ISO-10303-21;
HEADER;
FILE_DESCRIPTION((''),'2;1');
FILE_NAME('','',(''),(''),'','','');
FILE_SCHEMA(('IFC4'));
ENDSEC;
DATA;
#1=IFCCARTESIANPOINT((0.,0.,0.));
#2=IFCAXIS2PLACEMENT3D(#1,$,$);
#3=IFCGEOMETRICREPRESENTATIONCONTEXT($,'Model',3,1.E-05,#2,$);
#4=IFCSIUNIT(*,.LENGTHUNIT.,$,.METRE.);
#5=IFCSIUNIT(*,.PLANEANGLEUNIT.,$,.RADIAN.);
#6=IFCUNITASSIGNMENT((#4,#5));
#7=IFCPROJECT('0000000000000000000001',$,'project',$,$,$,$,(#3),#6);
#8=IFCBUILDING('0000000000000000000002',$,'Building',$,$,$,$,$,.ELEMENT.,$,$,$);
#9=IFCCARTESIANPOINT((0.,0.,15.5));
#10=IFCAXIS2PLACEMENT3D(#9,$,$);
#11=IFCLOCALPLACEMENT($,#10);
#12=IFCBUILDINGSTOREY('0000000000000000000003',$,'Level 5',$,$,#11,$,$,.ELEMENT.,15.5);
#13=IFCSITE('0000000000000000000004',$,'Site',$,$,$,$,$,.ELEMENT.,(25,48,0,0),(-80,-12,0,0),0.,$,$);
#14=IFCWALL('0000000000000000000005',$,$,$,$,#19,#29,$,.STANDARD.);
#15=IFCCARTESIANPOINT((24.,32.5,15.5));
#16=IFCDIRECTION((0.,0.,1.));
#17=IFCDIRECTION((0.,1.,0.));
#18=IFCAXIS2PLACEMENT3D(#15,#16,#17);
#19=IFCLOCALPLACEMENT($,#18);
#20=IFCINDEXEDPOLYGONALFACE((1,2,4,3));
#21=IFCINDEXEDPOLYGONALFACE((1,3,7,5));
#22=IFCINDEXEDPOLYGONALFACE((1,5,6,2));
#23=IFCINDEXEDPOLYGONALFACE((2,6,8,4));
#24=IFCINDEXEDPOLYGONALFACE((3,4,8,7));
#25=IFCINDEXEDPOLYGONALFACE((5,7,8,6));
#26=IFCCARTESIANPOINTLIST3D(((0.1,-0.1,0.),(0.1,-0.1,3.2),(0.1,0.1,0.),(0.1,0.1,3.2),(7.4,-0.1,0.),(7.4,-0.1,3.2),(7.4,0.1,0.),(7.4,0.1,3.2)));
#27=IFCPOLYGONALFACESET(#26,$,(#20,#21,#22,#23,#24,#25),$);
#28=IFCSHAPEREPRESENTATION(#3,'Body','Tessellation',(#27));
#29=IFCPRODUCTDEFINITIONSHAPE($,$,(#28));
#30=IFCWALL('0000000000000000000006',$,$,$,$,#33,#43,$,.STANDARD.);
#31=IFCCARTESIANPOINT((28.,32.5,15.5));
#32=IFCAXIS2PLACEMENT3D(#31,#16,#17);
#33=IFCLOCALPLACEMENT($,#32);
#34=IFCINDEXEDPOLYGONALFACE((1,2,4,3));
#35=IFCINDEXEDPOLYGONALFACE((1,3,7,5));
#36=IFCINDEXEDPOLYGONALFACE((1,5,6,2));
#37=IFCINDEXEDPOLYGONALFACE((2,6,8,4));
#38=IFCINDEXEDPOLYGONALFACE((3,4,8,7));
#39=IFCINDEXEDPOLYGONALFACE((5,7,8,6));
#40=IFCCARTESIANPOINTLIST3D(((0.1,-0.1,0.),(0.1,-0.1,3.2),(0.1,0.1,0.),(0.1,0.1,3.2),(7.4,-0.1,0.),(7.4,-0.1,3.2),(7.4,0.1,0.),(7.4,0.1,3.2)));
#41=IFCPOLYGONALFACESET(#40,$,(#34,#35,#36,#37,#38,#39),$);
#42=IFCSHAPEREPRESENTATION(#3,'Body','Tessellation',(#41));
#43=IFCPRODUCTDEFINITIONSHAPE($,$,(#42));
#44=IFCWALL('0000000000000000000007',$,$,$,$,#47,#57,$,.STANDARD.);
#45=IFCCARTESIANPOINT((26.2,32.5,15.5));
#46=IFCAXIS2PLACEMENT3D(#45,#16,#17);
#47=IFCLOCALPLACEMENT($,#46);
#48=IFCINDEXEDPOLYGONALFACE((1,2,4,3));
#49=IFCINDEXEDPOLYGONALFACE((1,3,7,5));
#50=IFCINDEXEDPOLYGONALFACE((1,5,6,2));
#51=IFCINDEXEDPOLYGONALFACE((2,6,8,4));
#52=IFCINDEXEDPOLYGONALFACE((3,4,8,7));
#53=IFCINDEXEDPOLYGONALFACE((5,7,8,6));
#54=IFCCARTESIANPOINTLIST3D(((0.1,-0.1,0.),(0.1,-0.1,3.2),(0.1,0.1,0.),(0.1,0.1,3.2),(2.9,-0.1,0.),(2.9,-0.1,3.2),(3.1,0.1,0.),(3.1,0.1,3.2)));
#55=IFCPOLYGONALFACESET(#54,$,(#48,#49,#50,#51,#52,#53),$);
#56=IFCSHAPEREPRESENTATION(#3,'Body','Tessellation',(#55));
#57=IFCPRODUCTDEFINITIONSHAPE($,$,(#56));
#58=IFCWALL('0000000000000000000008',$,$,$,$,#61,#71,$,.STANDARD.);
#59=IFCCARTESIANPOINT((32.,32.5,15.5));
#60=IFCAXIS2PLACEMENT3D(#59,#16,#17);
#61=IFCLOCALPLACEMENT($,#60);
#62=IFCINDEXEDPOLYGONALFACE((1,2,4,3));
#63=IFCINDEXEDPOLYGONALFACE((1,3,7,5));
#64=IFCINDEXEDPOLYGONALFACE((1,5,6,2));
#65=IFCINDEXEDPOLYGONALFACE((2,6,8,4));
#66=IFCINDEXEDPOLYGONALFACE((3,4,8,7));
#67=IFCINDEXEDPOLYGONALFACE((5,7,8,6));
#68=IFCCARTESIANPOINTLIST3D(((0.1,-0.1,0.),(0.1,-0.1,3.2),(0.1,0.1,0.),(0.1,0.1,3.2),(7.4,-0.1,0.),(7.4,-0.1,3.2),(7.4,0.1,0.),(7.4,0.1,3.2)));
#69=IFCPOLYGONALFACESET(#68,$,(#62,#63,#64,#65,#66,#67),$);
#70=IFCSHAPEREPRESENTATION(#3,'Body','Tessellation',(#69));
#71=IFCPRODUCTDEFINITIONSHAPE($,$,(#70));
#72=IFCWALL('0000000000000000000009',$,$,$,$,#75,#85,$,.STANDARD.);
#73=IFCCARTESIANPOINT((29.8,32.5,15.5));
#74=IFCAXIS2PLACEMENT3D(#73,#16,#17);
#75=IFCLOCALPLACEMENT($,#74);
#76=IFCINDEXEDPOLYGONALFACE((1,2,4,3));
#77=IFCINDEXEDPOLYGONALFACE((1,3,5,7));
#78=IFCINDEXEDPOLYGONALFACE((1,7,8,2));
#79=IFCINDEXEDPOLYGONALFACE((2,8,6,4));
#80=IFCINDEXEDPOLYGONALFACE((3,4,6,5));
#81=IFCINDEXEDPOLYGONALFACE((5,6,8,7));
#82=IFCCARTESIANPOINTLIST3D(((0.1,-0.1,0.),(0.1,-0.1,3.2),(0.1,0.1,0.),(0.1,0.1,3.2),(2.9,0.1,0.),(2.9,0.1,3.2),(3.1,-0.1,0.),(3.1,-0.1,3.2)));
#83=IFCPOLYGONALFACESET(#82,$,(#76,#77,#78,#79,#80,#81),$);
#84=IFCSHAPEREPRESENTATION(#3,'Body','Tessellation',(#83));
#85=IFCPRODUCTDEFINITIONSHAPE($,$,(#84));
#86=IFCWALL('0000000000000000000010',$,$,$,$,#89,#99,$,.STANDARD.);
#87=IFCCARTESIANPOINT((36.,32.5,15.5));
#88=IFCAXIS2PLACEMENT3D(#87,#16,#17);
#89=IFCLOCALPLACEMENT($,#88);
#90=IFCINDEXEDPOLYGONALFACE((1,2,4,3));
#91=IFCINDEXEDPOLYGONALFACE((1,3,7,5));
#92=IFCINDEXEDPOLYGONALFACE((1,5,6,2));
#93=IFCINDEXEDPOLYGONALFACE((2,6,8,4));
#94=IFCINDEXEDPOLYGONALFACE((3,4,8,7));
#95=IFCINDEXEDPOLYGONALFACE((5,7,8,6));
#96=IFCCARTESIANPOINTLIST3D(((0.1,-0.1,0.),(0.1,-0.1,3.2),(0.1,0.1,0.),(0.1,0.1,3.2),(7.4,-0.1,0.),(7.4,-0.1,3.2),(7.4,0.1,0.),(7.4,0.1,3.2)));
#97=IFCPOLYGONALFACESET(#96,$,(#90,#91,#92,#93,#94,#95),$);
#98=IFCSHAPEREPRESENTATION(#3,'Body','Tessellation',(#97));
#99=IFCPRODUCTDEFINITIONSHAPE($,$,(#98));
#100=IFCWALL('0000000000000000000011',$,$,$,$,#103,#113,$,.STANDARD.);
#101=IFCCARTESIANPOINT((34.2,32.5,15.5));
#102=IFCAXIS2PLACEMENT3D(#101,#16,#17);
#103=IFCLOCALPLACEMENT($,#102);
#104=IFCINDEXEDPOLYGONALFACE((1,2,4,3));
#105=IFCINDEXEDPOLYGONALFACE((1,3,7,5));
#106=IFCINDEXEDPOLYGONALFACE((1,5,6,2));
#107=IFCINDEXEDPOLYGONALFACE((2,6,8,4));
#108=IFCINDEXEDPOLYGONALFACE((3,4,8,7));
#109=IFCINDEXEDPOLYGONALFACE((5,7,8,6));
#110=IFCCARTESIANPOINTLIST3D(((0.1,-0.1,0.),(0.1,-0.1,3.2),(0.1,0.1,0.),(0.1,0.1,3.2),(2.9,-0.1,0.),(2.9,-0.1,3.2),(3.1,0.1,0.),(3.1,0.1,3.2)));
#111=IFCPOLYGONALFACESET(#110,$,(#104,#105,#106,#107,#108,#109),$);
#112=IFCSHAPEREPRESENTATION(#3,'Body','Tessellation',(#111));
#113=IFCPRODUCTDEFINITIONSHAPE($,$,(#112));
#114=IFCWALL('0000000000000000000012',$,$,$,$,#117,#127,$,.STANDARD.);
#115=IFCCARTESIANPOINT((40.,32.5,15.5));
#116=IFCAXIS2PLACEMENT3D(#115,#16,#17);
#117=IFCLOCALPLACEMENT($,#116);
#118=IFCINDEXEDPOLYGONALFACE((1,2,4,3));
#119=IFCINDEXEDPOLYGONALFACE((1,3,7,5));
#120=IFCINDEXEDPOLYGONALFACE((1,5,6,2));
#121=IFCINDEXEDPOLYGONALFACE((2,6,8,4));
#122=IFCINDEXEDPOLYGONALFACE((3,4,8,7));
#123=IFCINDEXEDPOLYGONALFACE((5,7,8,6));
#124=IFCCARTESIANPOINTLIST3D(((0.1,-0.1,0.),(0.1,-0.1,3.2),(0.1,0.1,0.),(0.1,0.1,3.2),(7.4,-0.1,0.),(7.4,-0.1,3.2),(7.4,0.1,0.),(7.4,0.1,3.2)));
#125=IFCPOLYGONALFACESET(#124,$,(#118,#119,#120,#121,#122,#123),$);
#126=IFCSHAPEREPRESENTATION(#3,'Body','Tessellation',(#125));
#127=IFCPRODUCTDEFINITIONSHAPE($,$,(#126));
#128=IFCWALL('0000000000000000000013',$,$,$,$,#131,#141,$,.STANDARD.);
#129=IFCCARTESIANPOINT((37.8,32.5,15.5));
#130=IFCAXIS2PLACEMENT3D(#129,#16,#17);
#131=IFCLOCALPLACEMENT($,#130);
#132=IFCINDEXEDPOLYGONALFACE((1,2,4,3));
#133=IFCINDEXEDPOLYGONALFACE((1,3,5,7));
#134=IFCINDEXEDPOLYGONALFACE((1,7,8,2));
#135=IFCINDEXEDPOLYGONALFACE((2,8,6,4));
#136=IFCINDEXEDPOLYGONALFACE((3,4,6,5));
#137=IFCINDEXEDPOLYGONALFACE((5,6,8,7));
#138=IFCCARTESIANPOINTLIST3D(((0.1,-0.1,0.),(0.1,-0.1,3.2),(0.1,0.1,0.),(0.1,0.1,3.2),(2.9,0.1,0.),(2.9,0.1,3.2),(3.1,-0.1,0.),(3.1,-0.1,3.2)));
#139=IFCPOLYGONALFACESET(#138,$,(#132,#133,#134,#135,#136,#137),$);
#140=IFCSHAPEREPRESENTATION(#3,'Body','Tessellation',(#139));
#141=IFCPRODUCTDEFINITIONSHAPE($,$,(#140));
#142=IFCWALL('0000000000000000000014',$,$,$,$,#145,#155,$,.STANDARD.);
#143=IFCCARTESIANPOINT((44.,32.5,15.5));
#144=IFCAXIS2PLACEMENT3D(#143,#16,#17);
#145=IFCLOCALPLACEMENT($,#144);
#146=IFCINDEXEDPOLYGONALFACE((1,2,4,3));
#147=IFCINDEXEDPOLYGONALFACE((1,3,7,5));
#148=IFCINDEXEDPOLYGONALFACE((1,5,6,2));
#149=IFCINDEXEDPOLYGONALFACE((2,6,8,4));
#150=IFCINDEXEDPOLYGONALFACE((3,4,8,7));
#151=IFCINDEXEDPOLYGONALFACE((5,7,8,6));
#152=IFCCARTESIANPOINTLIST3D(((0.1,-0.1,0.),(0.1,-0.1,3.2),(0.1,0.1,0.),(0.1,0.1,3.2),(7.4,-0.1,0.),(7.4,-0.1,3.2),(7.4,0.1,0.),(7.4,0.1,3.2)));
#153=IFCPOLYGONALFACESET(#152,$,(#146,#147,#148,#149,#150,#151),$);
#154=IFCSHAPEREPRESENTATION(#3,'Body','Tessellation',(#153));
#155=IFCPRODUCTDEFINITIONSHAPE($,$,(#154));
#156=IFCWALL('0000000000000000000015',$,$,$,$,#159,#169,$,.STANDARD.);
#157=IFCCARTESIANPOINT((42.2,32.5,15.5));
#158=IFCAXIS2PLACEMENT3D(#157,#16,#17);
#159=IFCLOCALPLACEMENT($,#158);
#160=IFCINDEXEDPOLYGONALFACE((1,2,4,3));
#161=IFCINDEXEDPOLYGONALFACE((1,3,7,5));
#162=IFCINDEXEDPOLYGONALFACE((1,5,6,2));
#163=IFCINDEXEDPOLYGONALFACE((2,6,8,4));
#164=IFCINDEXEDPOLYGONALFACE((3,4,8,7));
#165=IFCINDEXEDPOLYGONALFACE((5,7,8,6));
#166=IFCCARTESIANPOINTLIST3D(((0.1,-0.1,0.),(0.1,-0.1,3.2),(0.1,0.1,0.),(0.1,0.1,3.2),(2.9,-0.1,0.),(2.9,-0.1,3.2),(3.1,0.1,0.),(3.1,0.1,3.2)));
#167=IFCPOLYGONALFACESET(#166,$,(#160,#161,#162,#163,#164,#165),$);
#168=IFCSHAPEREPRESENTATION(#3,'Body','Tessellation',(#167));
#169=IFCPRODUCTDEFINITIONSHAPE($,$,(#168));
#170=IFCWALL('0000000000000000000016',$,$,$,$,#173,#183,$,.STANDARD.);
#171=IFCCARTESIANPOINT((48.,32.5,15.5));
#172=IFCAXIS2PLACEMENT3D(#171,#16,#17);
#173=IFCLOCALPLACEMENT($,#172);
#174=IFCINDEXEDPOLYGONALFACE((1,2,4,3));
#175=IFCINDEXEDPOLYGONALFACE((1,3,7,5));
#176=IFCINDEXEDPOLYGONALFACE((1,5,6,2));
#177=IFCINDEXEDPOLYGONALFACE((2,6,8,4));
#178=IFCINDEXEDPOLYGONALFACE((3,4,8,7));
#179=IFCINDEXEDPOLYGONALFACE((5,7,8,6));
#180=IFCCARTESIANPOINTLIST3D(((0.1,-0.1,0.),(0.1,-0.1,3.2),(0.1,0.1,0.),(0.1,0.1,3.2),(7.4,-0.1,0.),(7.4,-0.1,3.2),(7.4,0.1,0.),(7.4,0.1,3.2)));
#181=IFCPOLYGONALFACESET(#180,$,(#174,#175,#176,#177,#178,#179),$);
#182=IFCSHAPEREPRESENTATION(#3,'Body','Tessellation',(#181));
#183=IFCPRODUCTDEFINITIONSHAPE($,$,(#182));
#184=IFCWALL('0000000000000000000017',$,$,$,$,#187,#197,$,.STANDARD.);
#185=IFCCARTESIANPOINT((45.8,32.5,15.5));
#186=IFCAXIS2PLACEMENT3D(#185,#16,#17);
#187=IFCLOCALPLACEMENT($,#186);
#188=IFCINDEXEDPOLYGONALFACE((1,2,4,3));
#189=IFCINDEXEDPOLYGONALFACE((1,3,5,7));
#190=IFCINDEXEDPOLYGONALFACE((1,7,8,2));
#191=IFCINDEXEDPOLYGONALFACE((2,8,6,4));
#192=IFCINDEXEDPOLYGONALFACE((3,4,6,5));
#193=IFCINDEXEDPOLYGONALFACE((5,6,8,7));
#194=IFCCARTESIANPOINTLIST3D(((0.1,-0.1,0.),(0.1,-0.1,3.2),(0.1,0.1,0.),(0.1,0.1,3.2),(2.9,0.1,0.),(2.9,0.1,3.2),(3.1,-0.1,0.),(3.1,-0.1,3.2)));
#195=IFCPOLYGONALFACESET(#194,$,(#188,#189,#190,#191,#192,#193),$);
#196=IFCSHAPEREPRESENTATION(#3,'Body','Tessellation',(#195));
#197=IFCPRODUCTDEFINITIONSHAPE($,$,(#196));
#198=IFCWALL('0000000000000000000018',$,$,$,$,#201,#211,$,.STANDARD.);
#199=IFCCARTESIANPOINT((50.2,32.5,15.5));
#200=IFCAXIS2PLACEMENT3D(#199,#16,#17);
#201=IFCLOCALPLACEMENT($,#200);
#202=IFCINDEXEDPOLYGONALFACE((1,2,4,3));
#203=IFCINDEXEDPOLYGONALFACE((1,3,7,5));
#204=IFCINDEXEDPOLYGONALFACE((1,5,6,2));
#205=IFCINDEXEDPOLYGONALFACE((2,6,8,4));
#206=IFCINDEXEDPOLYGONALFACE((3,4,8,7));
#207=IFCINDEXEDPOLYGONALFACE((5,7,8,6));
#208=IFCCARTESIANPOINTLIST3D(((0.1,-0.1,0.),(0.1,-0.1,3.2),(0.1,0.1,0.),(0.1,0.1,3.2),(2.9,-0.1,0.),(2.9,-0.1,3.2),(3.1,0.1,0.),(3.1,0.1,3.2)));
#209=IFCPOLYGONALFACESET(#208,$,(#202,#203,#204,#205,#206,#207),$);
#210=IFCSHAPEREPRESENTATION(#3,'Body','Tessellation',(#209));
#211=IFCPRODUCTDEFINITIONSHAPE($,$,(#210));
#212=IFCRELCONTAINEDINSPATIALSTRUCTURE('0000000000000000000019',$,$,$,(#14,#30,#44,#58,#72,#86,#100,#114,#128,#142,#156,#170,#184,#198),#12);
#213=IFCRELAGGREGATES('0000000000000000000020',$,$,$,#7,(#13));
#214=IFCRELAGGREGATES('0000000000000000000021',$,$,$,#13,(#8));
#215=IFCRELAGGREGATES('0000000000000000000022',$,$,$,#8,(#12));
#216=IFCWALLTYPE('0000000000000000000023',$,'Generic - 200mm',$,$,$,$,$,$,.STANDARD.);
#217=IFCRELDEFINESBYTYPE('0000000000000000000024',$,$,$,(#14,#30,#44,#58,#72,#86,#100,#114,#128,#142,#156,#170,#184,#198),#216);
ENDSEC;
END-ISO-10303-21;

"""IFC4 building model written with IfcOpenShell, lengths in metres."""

from ifc_helpers import new_model, si_unit, frame, origin, place, context, project, spatial, polyline, outline, extrude, type_object, element, save


model = new_model("IFC4")

# Units and contexts
model_context = context("Model", 3, precision=1e-05, world=origin())
ifc_project = project(units=[si_unit("LENGTHUNIT", "METRE"), si_unit("PLANEANGLEUNIT", "RADIAN")], contexts=[model_context])

# Site, building, storey
site = spatial("IfcSite", under=ifc_project, Name="Site", CompositionType="ELEMENT", RefLatitude=(25, 48, 0, 0), RefLongitude=(-80, -12, 0, 0), RefElevation=0.0)
building = spatial("IfcBuilding", under=site, Name="Building", CompositionType="ELEMENT")
storey_placement = place(None, frame((0.0, 0.0, 15.5)))
storey = spatial("IfcBuildingStorey", under=building, at=storey_placement, Name="Level 5", CompositionType="ELEMENT", Elevation=15.5)

# Shared definitions
wall_type = type_object("IfcWallType", Name="Generic - 200mm", PredefinedType="STANDARD")

# Walls
for number, where, z_axis, x_axis in (
    (1, (24.0, 32.5, 15.5), (0.0, 0.0, 1.0), (0.0, 1.0, 0.0)),
    (2, (28.0, 32.5, 15.5), (0.0, 0.0, 1.0), (0.0, 1.0, 0.0)),
):
    element("IfcWall", number, at=place(None, frame(where, z_axis=z_axis, x_axis=x_axis)), inside=storey, type_object=wall_type, PredefinedType="STANDARD", context=model_context, shape_type="SweptSolid", body=[
        extrude(outline(polyline([(0.1, -0.1), (7.4, -0.1), (7.4, 0.1), (0.1, 0.1), (0.1, -0.1)])), origin(), (0.0, 0.0, 1.0), 3.2),
    ])
wall_1_placement = place(None, frame((26.2, 32.5, 15.5), z_axis=(0.0, 0.0, 1.0), x_axis=(0.0, 1.0, 0.0)))
element("IfcWall", 3, at=wall_1_placement, inside=storey, type_object=wall_type, PredefinedType="STANDARD", context=model_context, shape_type="SweptSolid", body=[
    extrude(outline(polyline([(0.1, -0.1), (2.9, -0.1), (3.1, 0.1), (0.1, 0.1), (0.1, -0.1)])), origin(), (0.0, 0.0, 1.0), 3.2),
])
wall_2_placement = place(None, frame((32.0, 32.5, 15.5), z_axis=(0.0, 0.0, 1.0), x_axis=(0.0, 1.0, 0.0)))
element("IfcWall", 4, at=wall_2_placement, inside=storey, type_object=wall_type, PredefinedType="STANDARD", context=model_context, shape_type="SweptSolid", body=[
    extrude(outline(polyline([(0.1, -0.1), (7.4, -0.1), (7.4, 0.1), (0.1, 0.1), (0.1, -0.1)])), origin(), (0.0, 0.0, 1.0), 3.2),
])
wall_3_placement = place(None, frame((29.8, 32.5, 15.5), z_axis=(0.0, 0.0, 1.0), x_axis=(0.0, 1.0, 0.0)))
element("IfcWall", 5, at=wall_3_placement, inside=storey, type_object=wall_type, PredefinedType="STANDARD", context=model_context, shape_type="SweptSolid", body=[
    extrude(outline(polyline([(0.1, -0.1), (3.1, -0.1), (2.9, 0.1), (0.1, 0.1), (0.1, -0.1)])), origin(), (0.0, 0.0, 1.0), 3.2),
])
wall_4_placement = place(None, frame((36.0, 32.5, 15.5), z_axis=(0.0, 0.0, 1.0), x_axis=(0.0, 1.0, 0.0)))
element("IfcWall", 6, at=wall_4_placement, inside=storey, type_object=wall_type, PredefinedType="STANDARD", context=model_context, shape_type="SweptSolid", body=[
    extrude(outline(polyline([(0.1, -0.1), (7.4, -0.1), (7.4, 0.1), (0.1, 0.1), (0.1, -0.1)])), origin(), (0.0, 0.0, 1.0), 3.2),
])
wall_5_placement = place(None, frame((34.2, 32.5, 15.5), z_axis=(0.0, 0.0, 1.0), x_axis=(0.0, 1.0, 0.0)))
element("IfcWall", 7, at=wall_5_placement, inside=storey, type_object=wall_type, PredefinedType="STANDARD", context=model_context, shape_type="SweptSolid", body=[
    extrude(outline(polyline([(0.1, -0.1), (2.9, -0.1), (3.1, 0.1), (0.1, 0.1), (0.1, -0.1)])), origin(), (0.0, 0.0, 1.0), 3.2),
])
wall_6_placement = place(None, frame((40.0, 32.5, 15.5), z_axis=(0.0, 0.0, 1.0), x_axis=(0.0, 1.0, 0.0)))
element("IfcWall", 8, at=wall_6_placement, inside=storey, type_object=wall_type, PredefinedType="STANDARD", context=model_context, shape_type="SweptSolid", body=[
    extrude(outline(polyline([(0.1, -0.1), (7.4, -0.1), (7.4, 0.1), (0.1, 0.1), (0.1, -0.1)])), origin(), (0.0, 0.0, 1.0), 3.2),
])
wall_7_placement = place(None, frame((37.8, 32.5, 15.5), z_axis=(0.0, 0.0, 1.0), x_axis=(0.0, 1.0, 0.0)))
element("IfcWall", 9, at=wall_7_placement, inside=storey, type_object=wall_type, PredefinedType="STANDARD", context=model_context, shape_type="SweptSolid", body=[
    extrude(outline(polyline([(0.1, -0.1), (3.1, -0.1), (2.9, 0.1), (0.1, 0.1), (0.1, -0.1)])), origin(), (0.0, 0.0, 1.0), 3.2),
])
wall_8_placement = place(None, frame((44.0, 32.5, 15.5), z_axis=(0.0, 0.0, 1.0), x_axis=(0.0, 1.0, 0.0)))
element("IfcWall", 10, at=wall_8_placement, inside=storey, type_object=wall_type, PredefinedType="STANDARD", context=model_context, shape_type="SweptSolid", body=[
    extrude(outline(polyline([(0.1, -0.1), (7.4, -0.1), (7.4, 0.1), (0.1, 0.1), (0.1, -0.1)])), origin(), (0.0, 0.0, 1.0), 3.2),
])
wall_9_placement = place(None, frame((42.2, 32.5, 15.5), z_axis=(0.0, 0.0, 1.0), x_axis=(0.0, 1.0, 0.0)))
element("IfcWall", 11, at=wall_9_placement, inside=storey, type_object=wall_type, PredefinedType="STANDARD", context=model_context, shape_type="SweptSolid", body=[
    extrude(outline(polyline([(0.1, -0.1), (2.9, -0.1), (3.1, 0.1), (0.1, 0.1), (0.1, -0.1)])), origin(), (0.0, 0.0, 1.0), 3.2),
])
wall_10_placement = place(None, frame((48.0, 32.5, 15.5), z_axis=(0.0, 0.0, 1.0), x_axis=(0.0, 1.0, 0.0)))
element("IfcWall", 12, at=wall_10_placement, inside=storey, type_object=wall_type, PredefinedType="STANDARD", context=model_context, shape_type="SweptSolid", body=[
    extrude(outline(polyline([(0.1, -0.1), (7.4, -0.1), (7.4, 0.1), (0.1, 0.1), (0.1, -0.1)])), origin(), (0.0, 0.0, 1.0), 3.2),
])
wall_11_placement = place(None, frame((45.8, 32.5, 15.5), z_axis=(0.0, 0.0, 1.0), x_axis=(0.0, 1.0, 0.0)))
element("IfcWall", 13, at=wall_11_placement, inside=storey, type_object=wall_type, PredefinedType="STANDARD", context=model_context, shape_type="SweptSolid", body=[
    extrude(outline(polyline([(0.1, -0.1), (3.1, -0.1), (2.9, 0.1), (0.1, 0.1), (0.1, -0.1)])), origin(), (0.0, 0.0, 1.0), 3.2),
])
wall_12_placement = place(None, frame((50.2, 32.5, 15.5), z_axis=(0.0, 0.0, 1.0), x_axis=(0.0, 1.0, 0.0)))
element("IfcWall", 14, at=wall_12_placement, inside=storey, type_object=wall_type, PredefinedType="STANDARD", context=model_context, shape_type="SweptSolid", body=[
    extrude(outline(polyline([(0.1, -0.1), (2.9, -0.1), (3.1, 0.1), (0.1, 0.1), (0.1, -0.1)])), origin(), (0.0, 0.0, 1.0), 3.2),
])

save(model, "model.ifc")
